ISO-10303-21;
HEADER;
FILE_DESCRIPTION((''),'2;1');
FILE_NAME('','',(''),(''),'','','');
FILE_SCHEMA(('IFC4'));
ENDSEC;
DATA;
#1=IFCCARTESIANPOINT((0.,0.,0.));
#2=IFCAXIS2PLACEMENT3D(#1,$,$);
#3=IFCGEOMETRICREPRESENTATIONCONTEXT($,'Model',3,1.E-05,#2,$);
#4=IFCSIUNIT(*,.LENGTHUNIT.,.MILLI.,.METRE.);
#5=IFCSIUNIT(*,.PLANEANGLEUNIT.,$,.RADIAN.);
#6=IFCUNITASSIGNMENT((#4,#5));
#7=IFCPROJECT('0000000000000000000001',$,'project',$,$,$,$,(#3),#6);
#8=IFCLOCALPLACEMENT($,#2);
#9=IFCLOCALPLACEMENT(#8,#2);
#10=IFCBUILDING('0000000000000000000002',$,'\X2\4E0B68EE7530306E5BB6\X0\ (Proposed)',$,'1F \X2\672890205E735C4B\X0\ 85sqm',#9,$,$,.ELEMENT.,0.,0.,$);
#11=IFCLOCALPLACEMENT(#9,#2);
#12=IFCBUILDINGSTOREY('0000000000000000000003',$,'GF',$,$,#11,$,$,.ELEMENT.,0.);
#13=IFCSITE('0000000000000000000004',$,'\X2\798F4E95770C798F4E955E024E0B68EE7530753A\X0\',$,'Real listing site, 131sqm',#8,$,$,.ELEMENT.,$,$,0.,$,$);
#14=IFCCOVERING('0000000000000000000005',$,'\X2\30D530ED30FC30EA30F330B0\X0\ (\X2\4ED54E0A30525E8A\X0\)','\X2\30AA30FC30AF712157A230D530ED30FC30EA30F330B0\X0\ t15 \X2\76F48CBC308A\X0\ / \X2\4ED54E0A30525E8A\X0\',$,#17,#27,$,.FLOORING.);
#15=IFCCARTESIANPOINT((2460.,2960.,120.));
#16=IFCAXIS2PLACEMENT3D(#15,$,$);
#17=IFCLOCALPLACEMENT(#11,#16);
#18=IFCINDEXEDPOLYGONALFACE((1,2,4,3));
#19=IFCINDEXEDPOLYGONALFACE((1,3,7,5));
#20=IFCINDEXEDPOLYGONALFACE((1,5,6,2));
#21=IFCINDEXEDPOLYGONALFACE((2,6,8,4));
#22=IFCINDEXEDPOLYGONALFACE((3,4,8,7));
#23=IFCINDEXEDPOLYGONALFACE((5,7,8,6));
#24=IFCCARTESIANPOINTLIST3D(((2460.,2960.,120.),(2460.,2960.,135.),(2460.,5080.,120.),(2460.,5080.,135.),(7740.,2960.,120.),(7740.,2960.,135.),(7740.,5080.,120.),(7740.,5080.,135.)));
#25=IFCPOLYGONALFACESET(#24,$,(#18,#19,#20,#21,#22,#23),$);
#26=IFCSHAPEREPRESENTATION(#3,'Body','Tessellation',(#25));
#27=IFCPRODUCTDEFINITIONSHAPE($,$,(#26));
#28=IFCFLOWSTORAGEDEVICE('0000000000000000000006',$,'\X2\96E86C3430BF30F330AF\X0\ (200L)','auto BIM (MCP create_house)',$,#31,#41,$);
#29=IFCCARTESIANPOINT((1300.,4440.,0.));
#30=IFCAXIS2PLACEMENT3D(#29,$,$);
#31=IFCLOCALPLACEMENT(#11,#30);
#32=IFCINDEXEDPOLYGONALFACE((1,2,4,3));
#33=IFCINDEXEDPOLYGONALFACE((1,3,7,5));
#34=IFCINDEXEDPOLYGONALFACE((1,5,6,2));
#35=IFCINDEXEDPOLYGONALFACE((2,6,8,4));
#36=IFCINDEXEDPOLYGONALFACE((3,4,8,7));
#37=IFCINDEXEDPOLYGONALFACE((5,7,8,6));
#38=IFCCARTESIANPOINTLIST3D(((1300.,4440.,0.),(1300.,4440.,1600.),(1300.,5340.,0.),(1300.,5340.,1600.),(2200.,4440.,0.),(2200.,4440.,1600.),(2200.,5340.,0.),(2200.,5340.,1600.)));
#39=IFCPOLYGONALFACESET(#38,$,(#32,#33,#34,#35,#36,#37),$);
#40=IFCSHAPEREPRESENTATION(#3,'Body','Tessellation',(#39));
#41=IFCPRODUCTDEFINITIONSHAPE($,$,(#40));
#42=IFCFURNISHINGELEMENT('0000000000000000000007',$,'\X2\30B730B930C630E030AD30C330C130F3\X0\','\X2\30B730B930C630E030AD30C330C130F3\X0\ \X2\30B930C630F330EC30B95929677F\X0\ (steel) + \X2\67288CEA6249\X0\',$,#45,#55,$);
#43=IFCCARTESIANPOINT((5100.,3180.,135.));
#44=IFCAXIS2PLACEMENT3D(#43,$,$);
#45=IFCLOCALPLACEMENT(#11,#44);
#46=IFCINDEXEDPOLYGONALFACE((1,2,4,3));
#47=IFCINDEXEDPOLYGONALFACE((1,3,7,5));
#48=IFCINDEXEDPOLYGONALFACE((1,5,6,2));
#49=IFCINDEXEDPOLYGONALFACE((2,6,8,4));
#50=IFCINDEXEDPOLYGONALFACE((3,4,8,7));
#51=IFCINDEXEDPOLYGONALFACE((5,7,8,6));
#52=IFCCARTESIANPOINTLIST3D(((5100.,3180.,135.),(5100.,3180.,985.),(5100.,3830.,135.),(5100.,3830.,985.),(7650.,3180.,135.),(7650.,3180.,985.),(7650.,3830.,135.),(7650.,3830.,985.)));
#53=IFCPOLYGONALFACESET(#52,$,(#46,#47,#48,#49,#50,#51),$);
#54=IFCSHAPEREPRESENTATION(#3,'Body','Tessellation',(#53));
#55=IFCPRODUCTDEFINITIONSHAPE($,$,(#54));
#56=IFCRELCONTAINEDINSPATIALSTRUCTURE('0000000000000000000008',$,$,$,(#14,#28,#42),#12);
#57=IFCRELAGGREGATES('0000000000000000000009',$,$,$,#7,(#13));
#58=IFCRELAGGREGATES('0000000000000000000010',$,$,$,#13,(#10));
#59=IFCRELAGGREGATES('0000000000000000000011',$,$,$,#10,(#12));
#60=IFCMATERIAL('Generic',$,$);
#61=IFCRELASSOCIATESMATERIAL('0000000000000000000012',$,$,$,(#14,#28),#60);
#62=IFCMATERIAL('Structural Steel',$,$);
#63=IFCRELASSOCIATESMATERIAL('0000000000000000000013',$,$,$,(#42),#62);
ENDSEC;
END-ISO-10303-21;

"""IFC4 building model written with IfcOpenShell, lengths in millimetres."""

from ifc_helpers import new_model, si_unit, frame, frame_2d, origin, place, context, project, spatial, rectangle, extrude, material, element, save


model = new_model("IFC4")

# Units and contexts
model_context = context("Model", 3, precision=1e-05, world=origin())
ifc_project = project(units=[si_unit("LENGTHUNIT", "METRE", prefix="MILLI"), si_unit("PLANEANGLEUNIT", "RADIAN")], contexts=[model_context])

# Site, building, storey
site_placement = place(None, origin())
site = spatial("IfcSite", under=ifc_project, at=site_placement, Name="福井県福井市下森田町", ObjectType="Real listing site, 131sqm", CompositionType="ELEMENT", RefElevation=0.0)
building_placement = place(site_placement, origin())
building = spatial("IfcBuilding", under=site, at=building_placement, Name="下森田の家 (Proposed)", ObjectType="1F 木造平屋 85sqm", CompositionType="ELEMENT", ElevationOfRefHeight=0.0, ElevationOfTerrain=0.0)
storey_placement = place(building_placement, origin())
storey = spatial("IfcBuildingStorey", under=building, at=storey_placement, Name="GF", CompositionType="ELEMENT", Elevation=0.0)

# Shared definitions
ifc_material_1 = material(Name="Generic")

# Covering
covering_placement = place(storey_placement, frame((2460.0, 2960.0, 120.0)))
element("IfcCovering", 1, at=covering_placement, inside=storey, material=ifc_material_1, Name="フローリング (仕上げ床)", Description="オーク無垢フローリング t15 直貼り / 仕上げ床", PredefinedType="FLOORING", context=model_context, shape_type="SweptSolid", body=[
    extrude(rectangle(XDim=5280.0, YDim=2120.0, at=frame_2d((2640.0, 1060.0))), frame((2460.0, 2960.0, 120.0)), (0.0, 0.0, 1.0), 15.0),
])

# Flow storage device
flow_storage_device_placement = place(storey_placement, frame((1300.0, 4440.0, 0.0)))
element("IfcFlowStorageDevice", 2, at=flow_storage_device_placement, inside=storey, material=ifc_material_1, Name="雨水タンク (200L)", Description="auto BIM (MCP create_house)", context=model_context, shape_type="SweptSolid", body=[
    extrude(rectangle(XDim=900.0, YDim=900.0, at=frame_2d((450.0, 450.0))), frame((1300.0, 4440.0, 0.0)), (0.0, 0.0, 1.0), 1600.0),
])

# Furnishing element
ifc_material_2 = material(Name="Structural Steel")
furnishing_placement = place(storey_placement, frame((5100.0, 3180.0, 135.0)))
element("IfcFurnishingElement", 3, at=furnishing_placement, inside=storey, material=ifc_material_2, Name="システムキッチン", Description="システムキッチン ステンレス天板 (steel) + 木質扉", context=model_context, shape_type="SweptSolid", body=[
    extrude(rectangle(XDim=2550.0, YDim=650.0, at=frame_2d((1275.0, 325.0))), frame((5100.0, 3180.0, 135.0)), (0.0, 0.0, 1.0), 850.0),
])

save(model, "model.ifc")
